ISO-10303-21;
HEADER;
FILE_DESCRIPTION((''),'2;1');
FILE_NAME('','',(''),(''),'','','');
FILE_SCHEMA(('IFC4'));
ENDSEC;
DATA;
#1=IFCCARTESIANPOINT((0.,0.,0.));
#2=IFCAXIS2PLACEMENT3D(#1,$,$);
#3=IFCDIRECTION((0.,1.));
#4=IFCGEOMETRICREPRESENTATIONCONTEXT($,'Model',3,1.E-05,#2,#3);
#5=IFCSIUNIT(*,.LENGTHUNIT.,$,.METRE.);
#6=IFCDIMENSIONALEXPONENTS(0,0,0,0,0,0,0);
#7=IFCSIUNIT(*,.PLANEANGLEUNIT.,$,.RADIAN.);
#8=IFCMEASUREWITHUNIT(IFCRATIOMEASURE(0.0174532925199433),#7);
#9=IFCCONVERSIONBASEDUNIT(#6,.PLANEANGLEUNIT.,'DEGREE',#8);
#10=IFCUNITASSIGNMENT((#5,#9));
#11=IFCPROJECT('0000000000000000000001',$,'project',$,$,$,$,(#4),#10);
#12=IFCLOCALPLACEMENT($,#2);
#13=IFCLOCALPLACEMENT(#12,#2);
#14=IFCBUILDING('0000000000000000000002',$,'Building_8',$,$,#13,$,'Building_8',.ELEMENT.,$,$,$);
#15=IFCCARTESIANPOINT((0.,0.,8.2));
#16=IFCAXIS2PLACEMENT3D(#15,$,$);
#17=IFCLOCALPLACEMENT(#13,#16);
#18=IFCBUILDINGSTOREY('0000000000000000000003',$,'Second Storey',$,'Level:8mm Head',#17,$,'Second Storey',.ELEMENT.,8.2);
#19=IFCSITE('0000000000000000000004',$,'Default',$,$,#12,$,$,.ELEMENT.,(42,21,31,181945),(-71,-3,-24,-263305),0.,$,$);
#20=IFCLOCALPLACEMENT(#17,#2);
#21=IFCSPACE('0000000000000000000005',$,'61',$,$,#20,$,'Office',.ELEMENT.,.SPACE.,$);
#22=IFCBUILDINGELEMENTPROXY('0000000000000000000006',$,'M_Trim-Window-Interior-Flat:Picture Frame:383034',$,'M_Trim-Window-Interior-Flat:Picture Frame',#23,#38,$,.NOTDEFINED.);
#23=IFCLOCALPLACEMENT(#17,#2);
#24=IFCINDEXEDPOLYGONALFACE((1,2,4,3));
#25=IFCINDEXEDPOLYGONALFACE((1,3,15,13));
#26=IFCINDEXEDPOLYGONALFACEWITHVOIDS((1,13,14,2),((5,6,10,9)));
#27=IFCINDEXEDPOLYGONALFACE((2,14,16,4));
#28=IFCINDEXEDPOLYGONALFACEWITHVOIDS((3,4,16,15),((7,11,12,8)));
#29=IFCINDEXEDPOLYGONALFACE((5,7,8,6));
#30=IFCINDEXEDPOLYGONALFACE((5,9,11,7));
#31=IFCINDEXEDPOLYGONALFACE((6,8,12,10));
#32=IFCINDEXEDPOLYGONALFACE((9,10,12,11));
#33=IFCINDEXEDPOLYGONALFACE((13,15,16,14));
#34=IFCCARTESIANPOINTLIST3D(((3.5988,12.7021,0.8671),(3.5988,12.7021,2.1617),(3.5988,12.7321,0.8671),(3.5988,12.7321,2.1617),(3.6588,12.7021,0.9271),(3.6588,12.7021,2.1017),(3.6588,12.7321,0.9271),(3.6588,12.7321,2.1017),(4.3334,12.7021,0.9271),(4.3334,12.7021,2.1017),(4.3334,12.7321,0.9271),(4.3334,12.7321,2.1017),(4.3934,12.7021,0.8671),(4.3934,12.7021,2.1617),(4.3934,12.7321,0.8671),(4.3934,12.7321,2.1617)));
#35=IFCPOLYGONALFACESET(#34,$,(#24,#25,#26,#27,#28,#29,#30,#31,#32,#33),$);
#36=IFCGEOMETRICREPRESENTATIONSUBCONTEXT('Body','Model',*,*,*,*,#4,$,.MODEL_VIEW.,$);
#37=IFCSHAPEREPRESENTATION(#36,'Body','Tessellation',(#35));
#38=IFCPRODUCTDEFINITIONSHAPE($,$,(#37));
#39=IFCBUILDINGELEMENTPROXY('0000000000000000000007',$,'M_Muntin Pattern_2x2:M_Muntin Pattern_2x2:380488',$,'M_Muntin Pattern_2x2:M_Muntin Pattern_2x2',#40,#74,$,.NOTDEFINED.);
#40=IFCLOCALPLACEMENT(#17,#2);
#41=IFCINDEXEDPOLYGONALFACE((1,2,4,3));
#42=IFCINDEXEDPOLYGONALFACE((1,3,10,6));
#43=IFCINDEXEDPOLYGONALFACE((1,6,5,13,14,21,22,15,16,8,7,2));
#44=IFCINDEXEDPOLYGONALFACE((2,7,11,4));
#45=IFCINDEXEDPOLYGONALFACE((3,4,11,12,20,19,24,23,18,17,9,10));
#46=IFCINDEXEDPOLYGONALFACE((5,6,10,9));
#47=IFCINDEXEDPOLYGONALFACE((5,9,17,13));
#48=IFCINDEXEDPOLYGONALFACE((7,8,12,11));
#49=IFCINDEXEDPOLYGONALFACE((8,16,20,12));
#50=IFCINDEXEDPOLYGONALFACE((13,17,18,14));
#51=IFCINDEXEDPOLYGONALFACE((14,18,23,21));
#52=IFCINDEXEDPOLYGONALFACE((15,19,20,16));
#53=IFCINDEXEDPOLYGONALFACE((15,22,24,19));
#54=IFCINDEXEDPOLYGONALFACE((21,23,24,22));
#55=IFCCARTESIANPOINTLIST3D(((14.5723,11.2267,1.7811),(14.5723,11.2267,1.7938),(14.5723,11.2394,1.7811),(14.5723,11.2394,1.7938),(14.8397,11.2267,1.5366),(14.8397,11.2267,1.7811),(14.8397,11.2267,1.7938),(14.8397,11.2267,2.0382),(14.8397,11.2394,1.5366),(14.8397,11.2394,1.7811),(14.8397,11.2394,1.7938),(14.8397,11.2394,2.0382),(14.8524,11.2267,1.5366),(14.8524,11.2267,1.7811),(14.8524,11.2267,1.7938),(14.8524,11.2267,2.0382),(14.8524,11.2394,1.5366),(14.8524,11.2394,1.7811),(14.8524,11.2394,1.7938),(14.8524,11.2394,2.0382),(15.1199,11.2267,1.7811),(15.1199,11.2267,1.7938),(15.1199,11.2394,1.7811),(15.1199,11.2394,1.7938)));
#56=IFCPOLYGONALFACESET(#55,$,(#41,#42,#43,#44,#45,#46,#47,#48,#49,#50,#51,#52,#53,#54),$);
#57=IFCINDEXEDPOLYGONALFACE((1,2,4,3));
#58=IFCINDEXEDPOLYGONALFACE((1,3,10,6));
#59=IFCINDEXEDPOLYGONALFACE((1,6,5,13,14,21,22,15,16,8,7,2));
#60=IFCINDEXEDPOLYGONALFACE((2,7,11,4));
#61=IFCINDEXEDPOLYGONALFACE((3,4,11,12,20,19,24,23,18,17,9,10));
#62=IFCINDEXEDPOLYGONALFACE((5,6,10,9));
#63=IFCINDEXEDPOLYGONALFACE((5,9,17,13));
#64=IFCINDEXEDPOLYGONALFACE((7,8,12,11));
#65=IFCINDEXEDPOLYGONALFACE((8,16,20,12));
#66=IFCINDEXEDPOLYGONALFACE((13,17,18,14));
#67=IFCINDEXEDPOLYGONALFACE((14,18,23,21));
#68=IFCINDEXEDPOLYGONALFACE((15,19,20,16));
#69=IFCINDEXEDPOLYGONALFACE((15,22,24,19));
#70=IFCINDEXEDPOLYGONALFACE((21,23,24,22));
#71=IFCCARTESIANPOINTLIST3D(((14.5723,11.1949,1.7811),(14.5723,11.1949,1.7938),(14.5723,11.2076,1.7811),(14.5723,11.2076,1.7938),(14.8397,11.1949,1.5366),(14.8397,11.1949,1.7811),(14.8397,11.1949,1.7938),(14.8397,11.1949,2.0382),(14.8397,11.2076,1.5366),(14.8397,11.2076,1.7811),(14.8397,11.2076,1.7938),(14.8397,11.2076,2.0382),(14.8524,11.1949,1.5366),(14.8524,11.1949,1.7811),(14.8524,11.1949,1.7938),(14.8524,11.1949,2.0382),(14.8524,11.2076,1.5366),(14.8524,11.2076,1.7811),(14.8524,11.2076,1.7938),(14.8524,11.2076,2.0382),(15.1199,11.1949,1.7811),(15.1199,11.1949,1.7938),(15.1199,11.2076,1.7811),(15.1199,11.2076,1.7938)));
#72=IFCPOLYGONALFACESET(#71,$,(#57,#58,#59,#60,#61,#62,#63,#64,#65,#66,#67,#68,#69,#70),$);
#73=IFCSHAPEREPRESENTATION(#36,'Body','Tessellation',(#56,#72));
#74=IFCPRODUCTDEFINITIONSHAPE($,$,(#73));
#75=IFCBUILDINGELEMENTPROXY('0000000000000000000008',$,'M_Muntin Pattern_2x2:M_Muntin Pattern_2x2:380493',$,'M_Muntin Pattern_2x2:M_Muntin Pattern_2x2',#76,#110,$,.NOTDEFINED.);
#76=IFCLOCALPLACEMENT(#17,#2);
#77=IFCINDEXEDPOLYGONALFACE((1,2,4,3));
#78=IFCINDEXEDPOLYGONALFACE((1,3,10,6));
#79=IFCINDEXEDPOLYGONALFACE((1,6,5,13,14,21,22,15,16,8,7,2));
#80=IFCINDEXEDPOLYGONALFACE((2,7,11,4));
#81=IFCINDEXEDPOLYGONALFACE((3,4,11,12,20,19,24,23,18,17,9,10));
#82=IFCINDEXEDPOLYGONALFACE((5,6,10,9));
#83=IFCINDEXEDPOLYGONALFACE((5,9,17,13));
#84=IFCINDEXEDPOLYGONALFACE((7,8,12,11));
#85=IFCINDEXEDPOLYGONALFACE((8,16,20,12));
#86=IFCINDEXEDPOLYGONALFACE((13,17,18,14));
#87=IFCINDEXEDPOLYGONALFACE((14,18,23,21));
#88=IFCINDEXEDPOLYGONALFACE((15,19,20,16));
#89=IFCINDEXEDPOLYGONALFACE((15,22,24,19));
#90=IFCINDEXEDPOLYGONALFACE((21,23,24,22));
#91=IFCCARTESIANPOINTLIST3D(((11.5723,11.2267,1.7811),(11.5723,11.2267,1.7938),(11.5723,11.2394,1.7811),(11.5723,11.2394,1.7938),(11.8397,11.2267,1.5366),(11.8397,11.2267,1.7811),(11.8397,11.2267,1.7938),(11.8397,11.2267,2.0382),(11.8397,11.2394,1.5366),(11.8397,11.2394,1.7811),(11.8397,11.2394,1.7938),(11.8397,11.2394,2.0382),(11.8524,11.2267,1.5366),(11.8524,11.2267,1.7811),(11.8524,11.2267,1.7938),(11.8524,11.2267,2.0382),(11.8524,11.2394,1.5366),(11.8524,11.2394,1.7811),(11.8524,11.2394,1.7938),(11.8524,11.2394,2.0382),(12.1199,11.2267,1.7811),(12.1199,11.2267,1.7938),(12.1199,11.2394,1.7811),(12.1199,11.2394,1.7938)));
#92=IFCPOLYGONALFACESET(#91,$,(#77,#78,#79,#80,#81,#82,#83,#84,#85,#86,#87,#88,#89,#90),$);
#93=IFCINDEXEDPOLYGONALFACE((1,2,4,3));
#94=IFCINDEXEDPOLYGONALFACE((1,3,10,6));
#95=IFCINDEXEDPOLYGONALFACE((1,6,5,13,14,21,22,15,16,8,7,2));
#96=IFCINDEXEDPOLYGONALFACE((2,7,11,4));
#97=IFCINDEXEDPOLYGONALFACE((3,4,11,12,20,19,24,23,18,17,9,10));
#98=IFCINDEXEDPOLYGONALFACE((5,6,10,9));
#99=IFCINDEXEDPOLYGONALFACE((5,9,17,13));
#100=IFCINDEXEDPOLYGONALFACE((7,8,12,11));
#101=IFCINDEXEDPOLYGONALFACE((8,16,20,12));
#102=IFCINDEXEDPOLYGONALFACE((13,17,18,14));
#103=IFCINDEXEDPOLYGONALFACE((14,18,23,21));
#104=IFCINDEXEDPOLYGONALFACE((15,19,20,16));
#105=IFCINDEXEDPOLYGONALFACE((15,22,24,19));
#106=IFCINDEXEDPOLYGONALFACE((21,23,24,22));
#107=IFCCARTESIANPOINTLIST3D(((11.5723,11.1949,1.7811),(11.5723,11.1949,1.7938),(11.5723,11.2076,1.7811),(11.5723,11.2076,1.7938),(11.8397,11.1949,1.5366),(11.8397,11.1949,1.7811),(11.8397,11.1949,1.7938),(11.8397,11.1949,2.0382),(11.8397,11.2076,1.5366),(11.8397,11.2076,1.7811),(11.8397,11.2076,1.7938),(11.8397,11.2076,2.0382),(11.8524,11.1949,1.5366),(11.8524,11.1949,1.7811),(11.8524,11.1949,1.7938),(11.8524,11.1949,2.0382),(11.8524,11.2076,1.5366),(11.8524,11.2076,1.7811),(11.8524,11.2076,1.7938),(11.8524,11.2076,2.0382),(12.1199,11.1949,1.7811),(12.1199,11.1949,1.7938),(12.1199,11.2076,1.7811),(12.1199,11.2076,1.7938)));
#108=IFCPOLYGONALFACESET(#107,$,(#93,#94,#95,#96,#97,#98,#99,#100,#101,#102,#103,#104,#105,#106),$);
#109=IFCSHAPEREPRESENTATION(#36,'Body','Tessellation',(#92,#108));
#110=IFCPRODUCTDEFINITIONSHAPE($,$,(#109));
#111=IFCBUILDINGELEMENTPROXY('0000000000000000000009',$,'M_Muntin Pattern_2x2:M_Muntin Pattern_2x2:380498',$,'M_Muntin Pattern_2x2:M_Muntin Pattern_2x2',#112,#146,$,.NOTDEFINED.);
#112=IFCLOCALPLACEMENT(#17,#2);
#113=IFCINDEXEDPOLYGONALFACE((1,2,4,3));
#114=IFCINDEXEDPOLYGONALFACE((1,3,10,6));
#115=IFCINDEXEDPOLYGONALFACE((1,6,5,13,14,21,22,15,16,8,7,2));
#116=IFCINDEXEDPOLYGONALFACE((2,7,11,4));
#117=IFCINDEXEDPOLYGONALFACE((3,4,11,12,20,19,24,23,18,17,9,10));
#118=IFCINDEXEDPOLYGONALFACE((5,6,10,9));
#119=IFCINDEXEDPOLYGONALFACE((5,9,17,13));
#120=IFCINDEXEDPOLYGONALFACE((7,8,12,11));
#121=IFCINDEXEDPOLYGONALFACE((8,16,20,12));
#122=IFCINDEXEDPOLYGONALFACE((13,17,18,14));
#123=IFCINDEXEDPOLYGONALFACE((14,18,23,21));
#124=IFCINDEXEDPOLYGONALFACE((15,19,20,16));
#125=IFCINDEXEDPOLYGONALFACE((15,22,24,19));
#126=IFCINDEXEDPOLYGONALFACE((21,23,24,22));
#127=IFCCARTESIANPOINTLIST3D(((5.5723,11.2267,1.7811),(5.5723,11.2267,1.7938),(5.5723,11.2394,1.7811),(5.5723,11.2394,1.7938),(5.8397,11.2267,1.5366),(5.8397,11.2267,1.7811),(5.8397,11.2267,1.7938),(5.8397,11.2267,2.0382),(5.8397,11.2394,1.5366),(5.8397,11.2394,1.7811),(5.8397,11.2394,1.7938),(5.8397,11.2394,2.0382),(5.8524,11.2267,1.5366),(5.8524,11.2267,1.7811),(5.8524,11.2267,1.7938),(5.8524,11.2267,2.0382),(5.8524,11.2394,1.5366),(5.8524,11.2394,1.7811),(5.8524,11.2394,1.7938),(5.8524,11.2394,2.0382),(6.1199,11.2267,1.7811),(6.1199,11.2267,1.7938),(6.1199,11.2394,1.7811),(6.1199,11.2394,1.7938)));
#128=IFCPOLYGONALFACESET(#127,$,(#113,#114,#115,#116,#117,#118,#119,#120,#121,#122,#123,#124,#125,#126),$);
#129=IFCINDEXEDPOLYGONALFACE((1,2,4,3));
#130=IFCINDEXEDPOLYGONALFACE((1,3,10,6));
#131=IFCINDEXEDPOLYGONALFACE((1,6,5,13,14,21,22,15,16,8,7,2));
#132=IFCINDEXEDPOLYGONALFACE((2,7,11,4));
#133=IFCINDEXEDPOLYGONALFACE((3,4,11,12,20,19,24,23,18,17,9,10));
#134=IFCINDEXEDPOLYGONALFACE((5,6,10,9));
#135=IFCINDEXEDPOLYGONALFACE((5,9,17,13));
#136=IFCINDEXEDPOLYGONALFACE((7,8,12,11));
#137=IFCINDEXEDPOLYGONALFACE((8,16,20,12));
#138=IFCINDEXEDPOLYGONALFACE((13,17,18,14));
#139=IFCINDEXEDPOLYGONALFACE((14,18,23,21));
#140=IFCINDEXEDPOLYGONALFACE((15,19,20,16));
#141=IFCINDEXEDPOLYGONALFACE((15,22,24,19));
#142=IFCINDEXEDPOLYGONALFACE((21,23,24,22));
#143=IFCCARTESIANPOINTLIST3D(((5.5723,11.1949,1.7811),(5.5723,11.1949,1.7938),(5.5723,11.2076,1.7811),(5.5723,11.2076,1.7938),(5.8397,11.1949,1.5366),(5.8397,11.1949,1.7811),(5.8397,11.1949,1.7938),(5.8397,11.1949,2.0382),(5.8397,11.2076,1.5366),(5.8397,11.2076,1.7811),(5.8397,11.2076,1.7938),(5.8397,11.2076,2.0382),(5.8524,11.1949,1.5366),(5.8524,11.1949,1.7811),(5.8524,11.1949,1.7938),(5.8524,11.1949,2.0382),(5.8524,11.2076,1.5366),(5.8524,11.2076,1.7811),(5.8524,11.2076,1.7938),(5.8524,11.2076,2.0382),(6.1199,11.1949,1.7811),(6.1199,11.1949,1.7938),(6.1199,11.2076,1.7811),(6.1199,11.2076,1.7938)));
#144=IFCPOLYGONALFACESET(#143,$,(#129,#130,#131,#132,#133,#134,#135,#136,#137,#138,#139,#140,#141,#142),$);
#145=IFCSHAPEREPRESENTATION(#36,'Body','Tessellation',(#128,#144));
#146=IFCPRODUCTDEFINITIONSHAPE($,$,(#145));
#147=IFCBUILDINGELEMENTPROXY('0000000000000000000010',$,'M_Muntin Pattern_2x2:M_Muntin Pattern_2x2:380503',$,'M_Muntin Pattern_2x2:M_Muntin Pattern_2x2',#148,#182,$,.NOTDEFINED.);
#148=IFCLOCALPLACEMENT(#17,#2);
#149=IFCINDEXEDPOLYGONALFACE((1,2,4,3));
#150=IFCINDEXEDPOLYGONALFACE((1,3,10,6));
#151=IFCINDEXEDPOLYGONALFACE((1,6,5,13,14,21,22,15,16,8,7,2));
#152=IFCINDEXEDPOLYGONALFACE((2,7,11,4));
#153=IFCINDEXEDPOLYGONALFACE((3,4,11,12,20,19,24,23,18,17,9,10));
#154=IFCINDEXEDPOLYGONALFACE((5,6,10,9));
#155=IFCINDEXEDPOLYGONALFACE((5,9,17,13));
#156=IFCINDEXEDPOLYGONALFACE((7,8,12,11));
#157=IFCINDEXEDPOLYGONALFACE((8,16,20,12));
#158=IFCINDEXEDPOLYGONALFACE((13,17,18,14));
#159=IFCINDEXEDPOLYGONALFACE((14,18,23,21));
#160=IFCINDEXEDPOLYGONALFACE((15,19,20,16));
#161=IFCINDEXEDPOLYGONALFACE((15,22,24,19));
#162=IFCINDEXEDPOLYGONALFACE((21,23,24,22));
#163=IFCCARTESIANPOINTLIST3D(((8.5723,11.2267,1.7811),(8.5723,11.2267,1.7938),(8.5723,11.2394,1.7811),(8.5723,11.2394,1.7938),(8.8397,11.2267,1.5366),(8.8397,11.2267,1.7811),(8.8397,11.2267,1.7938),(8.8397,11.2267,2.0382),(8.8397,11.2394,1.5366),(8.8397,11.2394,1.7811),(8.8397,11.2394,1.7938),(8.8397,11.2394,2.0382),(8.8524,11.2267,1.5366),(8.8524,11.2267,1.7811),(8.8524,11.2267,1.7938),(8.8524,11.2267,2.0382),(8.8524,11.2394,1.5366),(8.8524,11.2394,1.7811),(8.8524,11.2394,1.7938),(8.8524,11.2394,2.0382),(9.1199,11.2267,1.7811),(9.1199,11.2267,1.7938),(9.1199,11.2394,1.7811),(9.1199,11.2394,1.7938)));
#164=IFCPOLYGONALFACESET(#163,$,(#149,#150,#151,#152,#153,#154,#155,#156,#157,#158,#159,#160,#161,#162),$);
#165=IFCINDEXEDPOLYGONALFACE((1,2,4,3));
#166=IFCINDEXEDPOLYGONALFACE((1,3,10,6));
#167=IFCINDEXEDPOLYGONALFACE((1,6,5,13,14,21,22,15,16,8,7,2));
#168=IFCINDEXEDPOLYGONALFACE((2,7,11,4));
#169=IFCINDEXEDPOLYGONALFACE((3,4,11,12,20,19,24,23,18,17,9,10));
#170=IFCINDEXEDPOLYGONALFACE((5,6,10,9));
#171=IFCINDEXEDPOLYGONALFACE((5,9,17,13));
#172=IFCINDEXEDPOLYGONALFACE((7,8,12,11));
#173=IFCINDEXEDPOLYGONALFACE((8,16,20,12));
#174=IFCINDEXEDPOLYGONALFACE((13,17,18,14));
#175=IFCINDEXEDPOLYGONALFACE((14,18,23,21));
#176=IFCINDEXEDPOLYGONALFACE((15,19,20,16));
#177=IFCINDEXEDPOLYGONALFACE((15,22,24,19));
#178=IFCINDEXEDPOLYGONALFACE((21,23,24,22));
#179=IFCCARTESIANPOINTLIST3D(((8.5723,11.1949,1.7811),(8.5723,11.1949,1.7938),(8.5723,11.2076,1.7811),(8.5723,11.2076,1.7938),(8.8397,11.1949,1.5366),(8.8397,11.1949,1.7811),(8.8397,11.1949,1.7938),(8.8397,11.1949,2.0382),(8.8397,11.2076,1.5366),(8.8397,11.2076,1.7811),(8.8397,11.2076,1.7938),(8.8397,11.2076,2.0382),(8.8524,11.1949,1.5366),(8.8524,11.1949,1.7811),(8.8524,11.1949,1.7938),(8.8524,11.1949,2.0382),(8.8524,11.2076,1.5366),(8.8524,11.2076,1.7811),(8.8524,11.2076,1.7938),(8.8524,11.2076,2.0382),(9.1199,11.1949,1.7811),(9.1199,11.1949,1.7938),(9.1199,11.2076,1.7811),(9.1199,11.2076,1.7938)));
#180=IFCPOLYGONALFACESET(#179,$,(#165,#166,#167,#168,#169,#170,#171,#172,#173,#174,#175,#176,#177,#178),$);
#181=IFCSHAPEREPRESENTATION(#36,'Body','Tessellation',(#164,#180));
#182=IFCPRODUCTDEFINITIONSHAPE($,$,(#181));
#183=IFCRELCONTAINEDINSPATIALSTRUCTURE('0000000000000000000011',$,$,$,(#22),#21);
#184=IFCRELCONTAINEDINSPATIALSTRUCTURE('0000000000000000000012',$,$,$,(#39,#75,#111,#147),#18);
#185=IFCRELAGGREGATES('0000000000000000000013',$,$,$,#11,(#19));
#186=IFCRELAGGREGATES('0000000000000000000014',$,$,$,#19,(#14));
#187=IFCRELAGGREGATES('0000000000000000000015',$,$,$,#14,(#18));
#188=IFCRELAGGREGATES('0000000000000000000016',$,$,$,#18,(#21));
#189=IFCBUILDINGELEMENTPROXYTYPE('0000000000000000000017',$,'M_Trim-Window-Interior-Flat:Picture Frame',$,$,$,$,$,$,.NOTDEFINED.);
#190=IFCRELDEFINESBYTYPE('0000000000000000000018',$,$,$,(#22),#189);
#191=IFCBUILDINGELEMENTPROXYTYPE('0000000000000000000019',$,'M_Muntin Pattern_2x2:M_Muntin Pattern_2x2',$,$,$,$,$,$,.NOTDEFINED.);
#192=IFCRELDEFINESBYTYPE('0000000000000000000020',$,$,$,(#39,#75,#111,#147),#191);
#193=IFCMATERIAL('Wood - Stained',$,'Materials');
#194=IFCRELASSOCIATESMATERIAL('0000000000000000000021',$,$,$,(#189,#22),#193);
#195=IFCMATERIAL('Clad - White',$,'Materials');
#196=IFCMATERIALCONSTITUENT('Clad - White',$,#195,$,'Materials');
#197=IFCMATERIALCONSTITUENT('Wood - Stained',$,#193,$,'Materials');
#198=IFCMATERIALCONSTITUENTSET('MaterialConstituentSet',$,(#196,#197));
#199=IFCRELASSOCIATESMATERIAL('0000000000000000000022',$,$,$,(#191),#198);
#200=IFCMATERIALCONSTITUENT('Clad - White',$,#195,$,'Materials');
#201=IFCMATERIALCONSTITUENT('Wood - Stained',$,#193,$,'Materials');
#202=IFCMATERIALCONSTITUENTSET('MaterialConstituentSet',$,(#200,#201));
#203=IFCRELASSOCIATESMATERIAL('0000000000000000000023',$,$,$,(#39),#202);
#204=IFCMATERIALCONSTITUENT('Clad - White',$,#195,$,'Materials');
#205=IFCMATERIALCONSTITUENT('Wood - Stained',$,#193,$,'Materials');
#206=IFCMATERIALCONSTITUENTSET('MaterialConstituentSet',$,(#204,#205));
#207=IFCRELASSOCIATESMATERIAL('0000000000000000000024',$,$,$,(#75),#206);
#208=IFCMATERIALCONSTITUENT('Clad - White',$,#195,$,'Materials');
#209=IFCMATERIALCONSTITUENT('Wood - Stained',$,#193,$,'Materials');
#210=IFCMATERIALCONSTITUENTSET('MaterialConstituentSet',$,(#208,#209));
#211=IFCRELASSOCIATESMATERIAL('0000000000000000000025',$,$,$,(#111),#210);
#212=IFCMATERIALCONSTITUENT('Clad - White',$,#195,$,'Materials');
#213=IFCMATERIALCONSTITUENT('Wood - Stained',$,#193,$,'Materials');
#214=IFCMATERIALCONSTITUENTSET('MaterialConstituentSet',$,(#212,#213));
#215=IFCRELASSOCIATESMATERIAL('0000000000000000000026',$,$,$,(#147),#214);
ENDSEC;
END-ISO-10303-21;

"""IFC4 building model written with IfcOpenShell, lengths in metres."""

from ifc_helpers import new_model, entity, si_unit, converted_unit, direction, frame, origin, place, context, subcontext, project, spatial, indexed_curve, outline, extrude, source, transform, mapped, material, constituent, constituent_set, type_object, type_shapes, element, save


model = new_model("IFC4")

# Units and contexts
model_context = context("Model", 3, precision=1e-05, world=origin(), true_north=direction((0.0, 1.0)))
body_context = subcontext(model_context, "Body", "Model", "MODEL_VIEW")
ifc_project = project(units=[si_unit("LENGTHUNIT", "METRE"), converted_unit("PLANEANGLEUNIT", "DEGREE", entity("IfcRatioMeasure", 0.0174532925199433), si_unit("PLANEANGLEUNIT", "RADIAN"), dimensions=[0, 0, 0, 0, 0, 0, 0])], contexts=[model_context])

# Site, building, storey
site_placement = place(None, origin())
site = spatial("IfcSite", under=ifc_project, at=site_placement, Name="Default", CompositionType="ELEMENT", RefLatitude=(42, 21, 31, 181945), RefLongitude=(-71, -3, -24, -263305), RefElevation=0.0)
building_placement = place(site_placement, origin())
building = spatial("IfcBuilding", under=site, at=building_placement, Name="Building_8", LongName="Building_8", CompositionType="ELEMENT")
storey_placement = place(building_placement, frame((0.0, 0.0, 8.2)))
storey = spatial("IfcBuildingStorey", under=building, at=storey_placement, Name="Second Storey", ObjectType="Level:8mm Head", LongName="Second Storey", CompositionType="ELEMENT", Elevation=8.2)

# Shared definitions
ifc_material_1 = material(Name="Clad - White", Category="Materials")
ifc_material_2 = material(Name="Wood - Stained", Category="Materials")

# Shared definitions
building_element_proxy_type_1 = type_object("IfcBuildingElementProxyType", Name="M_Trim-Window-Interior-Flat:Picture Frame", PredefinedType="NOTDEFINED", material=ifc_material_2)
shared_shape_1 = source(origin(), body_context, "Body", "SweptSolid", [
    extrude(outline(indexed_curve([(-0.6473, -0.3973), (0.6473, -0.3973), (0.6473, 0.3973), (-0.6473, 0.3973), (-0.6473, -0.3973)], self_intersect=False), holes=[indexed_curve([(-0.5873, -0.3373), (-0.5873, 0.3373), (0.5873, 0.3373), (0.5873, -0.3373), (-0.5873, -0.3373)], self_intersect=False)]), frame((0.0, 0.6, 0.0), z_axis=(0.0, 0.0, 1.0), x_axis=(0.0, 1.0, 0.0)), (0.0, 0.0, 1.0), 0.03),
])
type_shapes(building_element_proxy_type_1, [shared_shape_1])

# Shared definitions
space_1_placement = place(storey_placement, origin())
space_1 = spatial("IfcSpace", under=storey, at=space_1_placement, Name="61", LongName="Office", CompositionType="ELEMENT", PredefinedType="SPACE")

# Building element proxies
proxy_1_placement = place(space_1_placement, frame((3.9961, 12.7021, 2.1144), z_axis=(0.0, 1.0, 0.0), x_axis=(1.0, 0.0, 0.0)))
element("IfcBuildingElementProxy", 1, at=proxy_1_placement, inside=space_1, type_object=building_element_proxy_type_1, material=ifc_material_2, Name="M_Trim-Window-Interior-Flat:Picture Frame:383034", ObjectType="M_Trim-Window-Interior-Flat:Picture Frame", PredefinedType="NOTDEFINED", context=body_context, shape_type="MappedRepresentation", body=[
    mapped(shared_shape_1, transform((0.0, 0.0, 0.0), scale=1.0)),
])
ifc_constituent_1 = constituent(ifc_material_1, Name="Clad - White", Category="Materials")
ifc_constituent_2 = constituent(ifc_material_2, Name="Wood - Stained", Category="Materials")
ifc_constituent_set_1 = constituent_set(constituents=[ifc_constituent_1, ifc_constituent_2], Name="MaterialConstituentSet")
ifc_constituent_3 = constituent(ifc_material_1, Name="Clad - White", Category="Materials")
ifc_constituent_4 = constituent(ifc_material_2, Name="Wood - Stained", Category="Materials")
ifc_constituent_set_2 = constituent_set(constituents=[ifc_constituent_3, ifc_constituent_4], Name="MaterialConstituentSet")
building_element_proxy_type_2 = type_object("IfcBuildingElementProxyType", Name="M_Muntin Pattern_2x2:M_Muntin Pattern_2x2", PredefinedType="NOTDEFINED", material=ifc_constituent_set_2)
shared_shape_2 = source(origin(), body_context, "Body", "SweptSolid", [
    extrude(outline(indexed_curve([(0.0064, -0.0064), (0.2508, -0.0064), (0.2508, 0.0063), (0.0064, 0.0063), (0.0064, 0.2738), (-0.0063, 0.2738), (-0.0063, 0.0063), (-0.2508, 0.0063), (-0.2508, -0.0064), (-0.0063, -0.0064), (-0.0063, -0.2738), (0.0064, -0.2738), (0.0064, -0.0064)], self_intersect=False)), frame((0.0, 0.0095, 0.2508), z_axis=(0.0, 1.0, 0.0), x_axis=(0.0, 0.0, 1.0)), (0.0, 0.0, 1.0), 0.0127),
    extrude(outline(indexed_curve([(0.0064, -0.0064), (0.2508, -0.0064), (0.2508, 0.0063), (0.0064, 0.0063), (0.0064, 0.2738), (-0.0063, 0.2738), (-0.0063, 0.0063), (-0.2508, 0.0063), (-0.2508, -0.0064), (-0.0063, -0.0064), (-0.0063, -0.2738), (0.0064, -0.2738), (0.0064, -0.0064)], self_intersect=False)), frame((0.0, -0.0222, 0.2508), z_axis=(0.0, 1.0, 0.0), x_axis=(0.0, 0.0, 1.0)), (0.0, 0.0, 1.0), 0.0127),
])
type_shapes(building_element_proxy_type_2, [shared_shape_2])
proxy_2_placement = place(storey_placement, frame((14.8461, 11.2171, 1.5366)))
element("IfcBuildingElementProxy", 2, at=proxy_2_placement, inside=storey, type_object=building_element_proxy_type_2, material=ifc_constituent_set_1, Name="M_Muntin Pattern_2x2:M_Muntin Pattern_2x2:380488", ObjectType="M_Muntin Pattern_2x2:M_Muntin Pattern_2x2", PredefinedType="NOTDEFINED", context=body_context, shape_type="MappedRepresentation", body=[
    mapped(shared_shape_2, transform((0.0, 0.0, 0.0), scale=1.0)),
])
ifc_constituent_5 = constituent(ifc_material_1, Name="Clad - White", Category="Materials")
ifc_constituent_6 = constituent(ifc_material_2, Name="Wood - Stained", Category="Materials")
ifc_constituent_set_3 = constituent_set(constituents=[ifc_constituent_5, ifc_constituent_6], Name="MaterialConstituentSet")
proxy_3_placement = place(storey_placement, frame((11.8461, 11.2171, 1.5366)))
element("IfcBuildingElementProxy", 3, at=proxy_3_placement, inside=storey, type_object=building_element_proxy_type_2, material=ifc_constituent_set_3, Name="M_Muntin Pattern_2x2:M_Muntin Pattern_2x2:380493", ObjectType="M_Muntin Pattern_2x2:M_Muntin Pattern_2x2", PredefinedType="NOTDEFINED", context=body_context, shape_type="MappedRepresentation", body=[
    mapped(shared_shape_2, transform((0.0, 0.0, 0.0), scale=1.0)),
])
ifc_constituent_7 = constituent(ifc_material_1, Name="Clad - White", Category="Materials")
ifc_constituent_8 = constituent(ifc_material_2, Name="Wood - Stained", Category="Materials")
ifc_constituent_set_4 = constituent_set(constituents=[ifc_constituent_7, ifc_constituent_8], Name="MaterialConstituentSet")
proxy_4_placement = place(storey_placement, frame((5.8461, 11.2171, 1.5366)))
element("IfcBuildingElementProxy", 4, at=proxy_4_placement, inside=storey, type_object=building_element_proxy_type_2, material=ifc_constituent_set_4, Name="M_Muntin Pattern_2x2:M_Muntin Pattern_2x2:380498", ObjectType="M_Muntin Pattern_2x2:M_Muntin Pattern_2x2", PredefinedType="NOTDEFINED", context=body_context, shape_type="MappedRepresentation", body=[
    mapped(shared_shape_2, transform((0.0, 0.0, 0.0), scale=1.0)),
])
ifc_constituent_9 = constituent(ifc_material_1, Name="Clad - White", Category="Materials")
ifc_constituent_10 = constituent(ifc_material_2, Name="Wood - Stained", Category="Materials")
ifc_constituent_set_5 = constituent_set(constituents=[ifc_constituent_9, ifc_constituent_10], Name="MaterialConstituentSet")
proxy_5_placement = place(storey_placement, frame((8.8461, 11.2171, 1.5366)))
element("IfcBuildingElementProxy", 5, at=proxy_5_placement, inside=storey, type_object=building_element_proxy_type_2, material=ifc_constituent_set_5, Name="M_Muntin Pattern_2x2:M_Muntin Pattern_2x2:380503", ObjectType="M_Muntin Pattern_2x2:M_Muntin Pattern_2x2", PredefinedType="NOTDEFINED", context=body_context, shape_type="MappedRepresentation", body=[
    mapped(shared_shape_2, transform((0.0, 0.0, 0.0), scale=1.0)),
])

save(model, "model.ifc")
